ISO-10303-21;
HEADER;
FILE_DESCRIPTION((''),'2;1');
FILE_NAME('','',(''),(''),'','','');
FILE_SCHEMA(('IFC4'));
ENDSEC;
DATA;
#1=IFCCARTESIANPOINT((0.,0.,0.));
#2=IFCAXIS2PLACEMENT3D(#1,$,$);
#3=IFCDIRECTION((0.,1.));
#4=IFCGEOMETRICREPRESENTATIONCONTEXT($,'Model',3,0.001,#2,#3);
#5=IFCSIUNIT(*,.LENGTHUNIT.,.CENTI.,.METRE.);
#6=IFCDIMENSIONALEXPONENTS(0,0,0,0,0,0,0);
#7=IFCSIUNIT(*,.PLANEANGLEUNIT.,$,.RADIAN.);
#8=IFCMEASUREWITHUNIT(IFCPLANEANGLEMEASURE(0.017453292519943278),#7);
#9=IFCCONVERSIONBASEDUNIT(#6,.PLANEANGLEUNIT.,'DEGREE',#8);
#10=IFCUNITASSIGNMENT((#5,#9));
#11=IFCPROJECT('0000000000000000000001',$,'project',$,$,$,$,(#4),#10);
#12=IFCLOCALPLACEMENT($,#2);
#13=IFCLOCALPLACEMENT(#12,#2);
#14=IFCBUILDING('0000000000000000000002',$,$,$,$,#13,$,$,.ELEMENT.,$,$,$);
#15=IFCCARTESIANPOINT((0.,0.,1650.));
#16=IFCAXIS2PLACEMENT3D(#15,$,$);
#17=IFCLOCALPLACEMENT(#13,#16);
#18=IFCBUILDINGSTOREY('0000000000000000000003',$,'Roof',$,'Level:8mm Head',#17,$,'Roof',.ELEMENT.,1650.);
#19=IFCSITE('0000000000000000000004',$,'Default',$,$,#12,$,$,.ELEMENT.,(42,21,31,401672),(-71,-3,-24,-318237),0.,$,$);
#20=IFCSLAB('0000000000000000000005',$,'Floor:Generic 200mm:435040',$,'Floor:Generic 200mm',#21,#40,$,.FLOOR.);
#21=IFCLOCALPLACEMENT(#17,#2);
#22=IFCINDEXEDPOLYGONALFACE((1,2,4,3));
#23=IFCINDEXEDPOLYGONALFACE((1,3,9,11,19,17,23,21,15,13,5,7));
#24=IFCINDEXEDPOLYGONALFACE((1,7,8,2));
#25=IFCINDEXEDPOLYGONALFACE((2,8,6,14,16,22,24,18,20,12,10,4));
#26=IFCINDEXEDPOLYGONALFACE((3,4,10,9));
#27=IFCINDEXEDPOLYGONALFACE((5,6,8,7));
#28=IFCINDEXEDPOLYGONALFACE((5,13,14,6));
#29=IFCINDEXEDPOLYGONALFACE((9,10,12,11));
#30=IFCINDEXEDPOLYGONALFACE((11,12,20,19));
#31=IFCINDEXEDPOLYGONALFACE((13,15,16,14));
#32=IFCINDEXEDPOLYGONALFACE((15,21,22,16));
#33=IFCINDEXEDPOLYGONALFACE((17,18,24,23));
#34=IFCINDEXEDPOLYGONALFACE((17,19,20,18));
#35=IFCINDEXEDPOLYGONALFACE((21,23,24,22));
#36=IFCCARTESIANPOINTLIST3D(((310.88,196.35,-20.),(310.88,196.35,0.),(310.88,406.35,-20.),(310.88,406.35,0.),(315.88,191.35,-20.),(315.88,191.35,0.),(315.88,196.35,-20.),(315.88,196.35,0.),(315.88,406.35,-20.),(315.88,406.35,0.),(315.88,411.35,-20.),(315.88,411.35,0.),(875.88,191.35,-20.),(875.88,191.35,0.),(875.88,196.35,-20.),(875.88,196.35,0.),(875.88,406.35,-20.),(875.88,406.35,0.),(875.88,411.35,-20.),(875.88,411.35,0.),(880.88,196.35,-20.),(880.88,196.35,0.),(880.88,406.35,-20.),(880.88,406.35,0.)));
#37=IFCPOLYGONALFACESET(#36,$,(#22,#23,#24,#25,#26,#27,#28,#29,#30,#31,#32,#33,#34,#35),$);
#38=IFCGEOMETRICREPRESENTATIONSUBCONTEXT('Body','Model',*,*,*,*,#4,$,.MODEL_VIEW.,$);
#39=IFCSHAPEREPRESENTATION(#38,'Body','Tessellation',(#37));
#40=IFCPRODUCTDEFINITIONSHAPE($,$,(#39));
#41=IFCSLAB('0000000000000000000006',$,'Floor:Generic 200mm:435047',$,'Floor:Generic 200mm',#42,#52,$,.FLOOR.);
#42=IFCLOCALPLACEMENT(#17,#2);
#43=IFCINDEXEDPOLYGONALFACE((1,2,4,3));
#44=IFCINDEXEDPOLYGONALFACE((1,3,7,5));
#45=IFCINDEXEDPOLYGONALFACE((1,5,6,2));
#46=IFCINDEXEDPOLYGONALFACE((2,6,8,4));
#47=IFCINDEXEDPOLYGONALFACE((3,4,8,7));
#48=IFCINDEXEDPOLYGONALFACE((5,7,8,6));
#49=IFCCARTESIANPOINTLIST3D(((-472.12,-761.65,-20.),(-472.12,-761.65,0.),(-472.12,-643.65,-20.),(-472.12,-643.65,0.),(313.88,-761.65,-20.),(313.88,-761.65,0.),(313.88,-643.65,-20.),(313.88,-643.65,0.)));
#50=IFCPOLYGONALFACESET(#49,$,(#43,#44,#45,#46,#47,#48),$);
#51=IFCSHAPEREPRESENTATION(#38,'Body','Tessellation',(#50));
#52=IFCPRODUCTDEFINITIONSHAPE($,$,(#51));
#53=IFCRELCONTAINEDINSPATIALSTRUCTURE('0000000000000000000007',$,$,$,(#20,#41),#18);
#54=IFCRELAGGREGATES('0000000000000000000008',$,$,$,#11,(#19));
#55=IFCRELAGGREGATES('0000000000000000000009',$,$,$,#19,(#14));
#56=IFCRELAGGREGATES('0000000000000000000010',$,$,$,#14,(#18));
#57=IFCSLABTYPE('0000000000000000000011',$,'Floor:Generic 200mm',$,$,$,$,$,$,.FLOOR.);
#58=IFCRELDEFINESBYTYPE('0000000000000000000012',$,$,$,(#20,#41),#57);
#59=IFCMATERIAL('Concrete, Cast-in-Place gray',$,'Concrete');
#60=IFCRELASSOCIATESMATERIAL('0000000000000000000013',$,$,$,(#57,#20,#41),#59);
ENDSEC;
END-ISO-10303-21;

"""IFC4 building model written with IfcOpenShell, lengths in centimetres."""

from ifc_helpers import new_model, entity, si_unit, converted_unit, direction, frame, origin, place, context, subcontext, project, spatial, indexed_curve, outline, extrude, material, type_object, element, save


model = new_model("IFC4")

# Units and contexts
model_context = context("Model", 3, precision=0.001, world=origin(), true_north=direction((0.0, 1.0)))
body_context = subcontext(model_context, "Body", "Model", "MODEL_VIEW")
ifc_project = project(units=[si_unit("LENGTHUNIT", "METRE", prefix="CENTI"), converted_unit("PLANEANGLEUNIT", "DEGREE", entity("IfcPlaneAngleMeasure", 0.017453292519943278), si_unit("PLANEANGLEUNIT", "RADIAN"), dimensions=[0, 0, 0, 0, 0, 0, 0])], contexts=[model_context])

# Site, building, storey
site_placement = place(None, origin())
site = spatial("IfcSite", under=ifc_project, at=site_placement, Name="Default", CompositionType="ELEMENT", RefLatitude=(42, 21, 31, 401672), RefLongitude=(-71, -3, -24, -318237), RefElevation=0.0)
building_placement = place(site_placement, origin())
building = spatial("IfcBuilding", under=site, at=building_placement, CompositionType="ELEMENT")
storey_placement = place(building_placement, frame((0.0, 0.0, 1650.0)))
storey = spatial("IfcBuildingStorey", under=building, at=storey_placement, Name="Roof", ObjectType="Level:8mm Head", LongName="Roof", CompositionType="ELEMENT", Elevation=1650.0)

# Slabs
ifc_material = material(Name="Concrete, Cast-in-Place gray", Category="Concrete")
slab_type = type_object("IfcSlabType", Name="Floor:Generic 200mm", PredefinedType="FLOOR", material=ifc_material)
slab_1_placement = place(storey_placement, origin())
element("IfcSlab", 1, at=slab_1_placement, inside=storey, type_object=slab_type, material=ifc_material, Name="Floor:Generic 200mm:435040", ObjectType="Floor:Generic 200mm", PredefinedType="FLOOR", context=body_context, shape_type="SweptSolid", body=[
    extrude(outline(indexed_curve([(-105.0, -285.0), (105.0, -285.0), (105.0, -280.0), (110.0, -280.0), (110.0, 280.0), (105.0, 280.0), (105.0, 285.0), (-105.0, 285.0), (-105.0, 280.0), (-110.0, 280.0), (-110.0, -280.0), (-105.0, -280.0), (-105.0, -285.0)], self_intersect=False)), frame((595.88, 301.35, 0.0), z_axis=(0.0, 0.0, -1.0), x_axis=(0.0, 1.0, 0.0)), (0.0, 0.0, 1.0), 20.0),
])
slab_2_placement = place(storey_placement, origin())
element("IfcSlab", 2, at=slab_2_placement, inside=storey, type_object=slab_type, material=ifc_material, Name="Floor:Generic 200mm:435047", ObjectType="Floor:Generic 200mm", PredefinedType="FLOOR", context=body_context, shape_type="SweptSolid", body=[
    extrude(outline(indexed_curve([(-59.0, -393.0), (59.0, -393.0), (59.0, 393.0), (-59.0, 393.0), (-59.0, -393.0)], self_intersect=False)), frame((-79.12, -702.65, 0.0), z_axis=(0.0, 0.0, -1.0), x_axis=(0.0, 1.0, 0.0)), (0.0, 0.0, 1.0), 20.0),
])

save(model, "model.ifc")
